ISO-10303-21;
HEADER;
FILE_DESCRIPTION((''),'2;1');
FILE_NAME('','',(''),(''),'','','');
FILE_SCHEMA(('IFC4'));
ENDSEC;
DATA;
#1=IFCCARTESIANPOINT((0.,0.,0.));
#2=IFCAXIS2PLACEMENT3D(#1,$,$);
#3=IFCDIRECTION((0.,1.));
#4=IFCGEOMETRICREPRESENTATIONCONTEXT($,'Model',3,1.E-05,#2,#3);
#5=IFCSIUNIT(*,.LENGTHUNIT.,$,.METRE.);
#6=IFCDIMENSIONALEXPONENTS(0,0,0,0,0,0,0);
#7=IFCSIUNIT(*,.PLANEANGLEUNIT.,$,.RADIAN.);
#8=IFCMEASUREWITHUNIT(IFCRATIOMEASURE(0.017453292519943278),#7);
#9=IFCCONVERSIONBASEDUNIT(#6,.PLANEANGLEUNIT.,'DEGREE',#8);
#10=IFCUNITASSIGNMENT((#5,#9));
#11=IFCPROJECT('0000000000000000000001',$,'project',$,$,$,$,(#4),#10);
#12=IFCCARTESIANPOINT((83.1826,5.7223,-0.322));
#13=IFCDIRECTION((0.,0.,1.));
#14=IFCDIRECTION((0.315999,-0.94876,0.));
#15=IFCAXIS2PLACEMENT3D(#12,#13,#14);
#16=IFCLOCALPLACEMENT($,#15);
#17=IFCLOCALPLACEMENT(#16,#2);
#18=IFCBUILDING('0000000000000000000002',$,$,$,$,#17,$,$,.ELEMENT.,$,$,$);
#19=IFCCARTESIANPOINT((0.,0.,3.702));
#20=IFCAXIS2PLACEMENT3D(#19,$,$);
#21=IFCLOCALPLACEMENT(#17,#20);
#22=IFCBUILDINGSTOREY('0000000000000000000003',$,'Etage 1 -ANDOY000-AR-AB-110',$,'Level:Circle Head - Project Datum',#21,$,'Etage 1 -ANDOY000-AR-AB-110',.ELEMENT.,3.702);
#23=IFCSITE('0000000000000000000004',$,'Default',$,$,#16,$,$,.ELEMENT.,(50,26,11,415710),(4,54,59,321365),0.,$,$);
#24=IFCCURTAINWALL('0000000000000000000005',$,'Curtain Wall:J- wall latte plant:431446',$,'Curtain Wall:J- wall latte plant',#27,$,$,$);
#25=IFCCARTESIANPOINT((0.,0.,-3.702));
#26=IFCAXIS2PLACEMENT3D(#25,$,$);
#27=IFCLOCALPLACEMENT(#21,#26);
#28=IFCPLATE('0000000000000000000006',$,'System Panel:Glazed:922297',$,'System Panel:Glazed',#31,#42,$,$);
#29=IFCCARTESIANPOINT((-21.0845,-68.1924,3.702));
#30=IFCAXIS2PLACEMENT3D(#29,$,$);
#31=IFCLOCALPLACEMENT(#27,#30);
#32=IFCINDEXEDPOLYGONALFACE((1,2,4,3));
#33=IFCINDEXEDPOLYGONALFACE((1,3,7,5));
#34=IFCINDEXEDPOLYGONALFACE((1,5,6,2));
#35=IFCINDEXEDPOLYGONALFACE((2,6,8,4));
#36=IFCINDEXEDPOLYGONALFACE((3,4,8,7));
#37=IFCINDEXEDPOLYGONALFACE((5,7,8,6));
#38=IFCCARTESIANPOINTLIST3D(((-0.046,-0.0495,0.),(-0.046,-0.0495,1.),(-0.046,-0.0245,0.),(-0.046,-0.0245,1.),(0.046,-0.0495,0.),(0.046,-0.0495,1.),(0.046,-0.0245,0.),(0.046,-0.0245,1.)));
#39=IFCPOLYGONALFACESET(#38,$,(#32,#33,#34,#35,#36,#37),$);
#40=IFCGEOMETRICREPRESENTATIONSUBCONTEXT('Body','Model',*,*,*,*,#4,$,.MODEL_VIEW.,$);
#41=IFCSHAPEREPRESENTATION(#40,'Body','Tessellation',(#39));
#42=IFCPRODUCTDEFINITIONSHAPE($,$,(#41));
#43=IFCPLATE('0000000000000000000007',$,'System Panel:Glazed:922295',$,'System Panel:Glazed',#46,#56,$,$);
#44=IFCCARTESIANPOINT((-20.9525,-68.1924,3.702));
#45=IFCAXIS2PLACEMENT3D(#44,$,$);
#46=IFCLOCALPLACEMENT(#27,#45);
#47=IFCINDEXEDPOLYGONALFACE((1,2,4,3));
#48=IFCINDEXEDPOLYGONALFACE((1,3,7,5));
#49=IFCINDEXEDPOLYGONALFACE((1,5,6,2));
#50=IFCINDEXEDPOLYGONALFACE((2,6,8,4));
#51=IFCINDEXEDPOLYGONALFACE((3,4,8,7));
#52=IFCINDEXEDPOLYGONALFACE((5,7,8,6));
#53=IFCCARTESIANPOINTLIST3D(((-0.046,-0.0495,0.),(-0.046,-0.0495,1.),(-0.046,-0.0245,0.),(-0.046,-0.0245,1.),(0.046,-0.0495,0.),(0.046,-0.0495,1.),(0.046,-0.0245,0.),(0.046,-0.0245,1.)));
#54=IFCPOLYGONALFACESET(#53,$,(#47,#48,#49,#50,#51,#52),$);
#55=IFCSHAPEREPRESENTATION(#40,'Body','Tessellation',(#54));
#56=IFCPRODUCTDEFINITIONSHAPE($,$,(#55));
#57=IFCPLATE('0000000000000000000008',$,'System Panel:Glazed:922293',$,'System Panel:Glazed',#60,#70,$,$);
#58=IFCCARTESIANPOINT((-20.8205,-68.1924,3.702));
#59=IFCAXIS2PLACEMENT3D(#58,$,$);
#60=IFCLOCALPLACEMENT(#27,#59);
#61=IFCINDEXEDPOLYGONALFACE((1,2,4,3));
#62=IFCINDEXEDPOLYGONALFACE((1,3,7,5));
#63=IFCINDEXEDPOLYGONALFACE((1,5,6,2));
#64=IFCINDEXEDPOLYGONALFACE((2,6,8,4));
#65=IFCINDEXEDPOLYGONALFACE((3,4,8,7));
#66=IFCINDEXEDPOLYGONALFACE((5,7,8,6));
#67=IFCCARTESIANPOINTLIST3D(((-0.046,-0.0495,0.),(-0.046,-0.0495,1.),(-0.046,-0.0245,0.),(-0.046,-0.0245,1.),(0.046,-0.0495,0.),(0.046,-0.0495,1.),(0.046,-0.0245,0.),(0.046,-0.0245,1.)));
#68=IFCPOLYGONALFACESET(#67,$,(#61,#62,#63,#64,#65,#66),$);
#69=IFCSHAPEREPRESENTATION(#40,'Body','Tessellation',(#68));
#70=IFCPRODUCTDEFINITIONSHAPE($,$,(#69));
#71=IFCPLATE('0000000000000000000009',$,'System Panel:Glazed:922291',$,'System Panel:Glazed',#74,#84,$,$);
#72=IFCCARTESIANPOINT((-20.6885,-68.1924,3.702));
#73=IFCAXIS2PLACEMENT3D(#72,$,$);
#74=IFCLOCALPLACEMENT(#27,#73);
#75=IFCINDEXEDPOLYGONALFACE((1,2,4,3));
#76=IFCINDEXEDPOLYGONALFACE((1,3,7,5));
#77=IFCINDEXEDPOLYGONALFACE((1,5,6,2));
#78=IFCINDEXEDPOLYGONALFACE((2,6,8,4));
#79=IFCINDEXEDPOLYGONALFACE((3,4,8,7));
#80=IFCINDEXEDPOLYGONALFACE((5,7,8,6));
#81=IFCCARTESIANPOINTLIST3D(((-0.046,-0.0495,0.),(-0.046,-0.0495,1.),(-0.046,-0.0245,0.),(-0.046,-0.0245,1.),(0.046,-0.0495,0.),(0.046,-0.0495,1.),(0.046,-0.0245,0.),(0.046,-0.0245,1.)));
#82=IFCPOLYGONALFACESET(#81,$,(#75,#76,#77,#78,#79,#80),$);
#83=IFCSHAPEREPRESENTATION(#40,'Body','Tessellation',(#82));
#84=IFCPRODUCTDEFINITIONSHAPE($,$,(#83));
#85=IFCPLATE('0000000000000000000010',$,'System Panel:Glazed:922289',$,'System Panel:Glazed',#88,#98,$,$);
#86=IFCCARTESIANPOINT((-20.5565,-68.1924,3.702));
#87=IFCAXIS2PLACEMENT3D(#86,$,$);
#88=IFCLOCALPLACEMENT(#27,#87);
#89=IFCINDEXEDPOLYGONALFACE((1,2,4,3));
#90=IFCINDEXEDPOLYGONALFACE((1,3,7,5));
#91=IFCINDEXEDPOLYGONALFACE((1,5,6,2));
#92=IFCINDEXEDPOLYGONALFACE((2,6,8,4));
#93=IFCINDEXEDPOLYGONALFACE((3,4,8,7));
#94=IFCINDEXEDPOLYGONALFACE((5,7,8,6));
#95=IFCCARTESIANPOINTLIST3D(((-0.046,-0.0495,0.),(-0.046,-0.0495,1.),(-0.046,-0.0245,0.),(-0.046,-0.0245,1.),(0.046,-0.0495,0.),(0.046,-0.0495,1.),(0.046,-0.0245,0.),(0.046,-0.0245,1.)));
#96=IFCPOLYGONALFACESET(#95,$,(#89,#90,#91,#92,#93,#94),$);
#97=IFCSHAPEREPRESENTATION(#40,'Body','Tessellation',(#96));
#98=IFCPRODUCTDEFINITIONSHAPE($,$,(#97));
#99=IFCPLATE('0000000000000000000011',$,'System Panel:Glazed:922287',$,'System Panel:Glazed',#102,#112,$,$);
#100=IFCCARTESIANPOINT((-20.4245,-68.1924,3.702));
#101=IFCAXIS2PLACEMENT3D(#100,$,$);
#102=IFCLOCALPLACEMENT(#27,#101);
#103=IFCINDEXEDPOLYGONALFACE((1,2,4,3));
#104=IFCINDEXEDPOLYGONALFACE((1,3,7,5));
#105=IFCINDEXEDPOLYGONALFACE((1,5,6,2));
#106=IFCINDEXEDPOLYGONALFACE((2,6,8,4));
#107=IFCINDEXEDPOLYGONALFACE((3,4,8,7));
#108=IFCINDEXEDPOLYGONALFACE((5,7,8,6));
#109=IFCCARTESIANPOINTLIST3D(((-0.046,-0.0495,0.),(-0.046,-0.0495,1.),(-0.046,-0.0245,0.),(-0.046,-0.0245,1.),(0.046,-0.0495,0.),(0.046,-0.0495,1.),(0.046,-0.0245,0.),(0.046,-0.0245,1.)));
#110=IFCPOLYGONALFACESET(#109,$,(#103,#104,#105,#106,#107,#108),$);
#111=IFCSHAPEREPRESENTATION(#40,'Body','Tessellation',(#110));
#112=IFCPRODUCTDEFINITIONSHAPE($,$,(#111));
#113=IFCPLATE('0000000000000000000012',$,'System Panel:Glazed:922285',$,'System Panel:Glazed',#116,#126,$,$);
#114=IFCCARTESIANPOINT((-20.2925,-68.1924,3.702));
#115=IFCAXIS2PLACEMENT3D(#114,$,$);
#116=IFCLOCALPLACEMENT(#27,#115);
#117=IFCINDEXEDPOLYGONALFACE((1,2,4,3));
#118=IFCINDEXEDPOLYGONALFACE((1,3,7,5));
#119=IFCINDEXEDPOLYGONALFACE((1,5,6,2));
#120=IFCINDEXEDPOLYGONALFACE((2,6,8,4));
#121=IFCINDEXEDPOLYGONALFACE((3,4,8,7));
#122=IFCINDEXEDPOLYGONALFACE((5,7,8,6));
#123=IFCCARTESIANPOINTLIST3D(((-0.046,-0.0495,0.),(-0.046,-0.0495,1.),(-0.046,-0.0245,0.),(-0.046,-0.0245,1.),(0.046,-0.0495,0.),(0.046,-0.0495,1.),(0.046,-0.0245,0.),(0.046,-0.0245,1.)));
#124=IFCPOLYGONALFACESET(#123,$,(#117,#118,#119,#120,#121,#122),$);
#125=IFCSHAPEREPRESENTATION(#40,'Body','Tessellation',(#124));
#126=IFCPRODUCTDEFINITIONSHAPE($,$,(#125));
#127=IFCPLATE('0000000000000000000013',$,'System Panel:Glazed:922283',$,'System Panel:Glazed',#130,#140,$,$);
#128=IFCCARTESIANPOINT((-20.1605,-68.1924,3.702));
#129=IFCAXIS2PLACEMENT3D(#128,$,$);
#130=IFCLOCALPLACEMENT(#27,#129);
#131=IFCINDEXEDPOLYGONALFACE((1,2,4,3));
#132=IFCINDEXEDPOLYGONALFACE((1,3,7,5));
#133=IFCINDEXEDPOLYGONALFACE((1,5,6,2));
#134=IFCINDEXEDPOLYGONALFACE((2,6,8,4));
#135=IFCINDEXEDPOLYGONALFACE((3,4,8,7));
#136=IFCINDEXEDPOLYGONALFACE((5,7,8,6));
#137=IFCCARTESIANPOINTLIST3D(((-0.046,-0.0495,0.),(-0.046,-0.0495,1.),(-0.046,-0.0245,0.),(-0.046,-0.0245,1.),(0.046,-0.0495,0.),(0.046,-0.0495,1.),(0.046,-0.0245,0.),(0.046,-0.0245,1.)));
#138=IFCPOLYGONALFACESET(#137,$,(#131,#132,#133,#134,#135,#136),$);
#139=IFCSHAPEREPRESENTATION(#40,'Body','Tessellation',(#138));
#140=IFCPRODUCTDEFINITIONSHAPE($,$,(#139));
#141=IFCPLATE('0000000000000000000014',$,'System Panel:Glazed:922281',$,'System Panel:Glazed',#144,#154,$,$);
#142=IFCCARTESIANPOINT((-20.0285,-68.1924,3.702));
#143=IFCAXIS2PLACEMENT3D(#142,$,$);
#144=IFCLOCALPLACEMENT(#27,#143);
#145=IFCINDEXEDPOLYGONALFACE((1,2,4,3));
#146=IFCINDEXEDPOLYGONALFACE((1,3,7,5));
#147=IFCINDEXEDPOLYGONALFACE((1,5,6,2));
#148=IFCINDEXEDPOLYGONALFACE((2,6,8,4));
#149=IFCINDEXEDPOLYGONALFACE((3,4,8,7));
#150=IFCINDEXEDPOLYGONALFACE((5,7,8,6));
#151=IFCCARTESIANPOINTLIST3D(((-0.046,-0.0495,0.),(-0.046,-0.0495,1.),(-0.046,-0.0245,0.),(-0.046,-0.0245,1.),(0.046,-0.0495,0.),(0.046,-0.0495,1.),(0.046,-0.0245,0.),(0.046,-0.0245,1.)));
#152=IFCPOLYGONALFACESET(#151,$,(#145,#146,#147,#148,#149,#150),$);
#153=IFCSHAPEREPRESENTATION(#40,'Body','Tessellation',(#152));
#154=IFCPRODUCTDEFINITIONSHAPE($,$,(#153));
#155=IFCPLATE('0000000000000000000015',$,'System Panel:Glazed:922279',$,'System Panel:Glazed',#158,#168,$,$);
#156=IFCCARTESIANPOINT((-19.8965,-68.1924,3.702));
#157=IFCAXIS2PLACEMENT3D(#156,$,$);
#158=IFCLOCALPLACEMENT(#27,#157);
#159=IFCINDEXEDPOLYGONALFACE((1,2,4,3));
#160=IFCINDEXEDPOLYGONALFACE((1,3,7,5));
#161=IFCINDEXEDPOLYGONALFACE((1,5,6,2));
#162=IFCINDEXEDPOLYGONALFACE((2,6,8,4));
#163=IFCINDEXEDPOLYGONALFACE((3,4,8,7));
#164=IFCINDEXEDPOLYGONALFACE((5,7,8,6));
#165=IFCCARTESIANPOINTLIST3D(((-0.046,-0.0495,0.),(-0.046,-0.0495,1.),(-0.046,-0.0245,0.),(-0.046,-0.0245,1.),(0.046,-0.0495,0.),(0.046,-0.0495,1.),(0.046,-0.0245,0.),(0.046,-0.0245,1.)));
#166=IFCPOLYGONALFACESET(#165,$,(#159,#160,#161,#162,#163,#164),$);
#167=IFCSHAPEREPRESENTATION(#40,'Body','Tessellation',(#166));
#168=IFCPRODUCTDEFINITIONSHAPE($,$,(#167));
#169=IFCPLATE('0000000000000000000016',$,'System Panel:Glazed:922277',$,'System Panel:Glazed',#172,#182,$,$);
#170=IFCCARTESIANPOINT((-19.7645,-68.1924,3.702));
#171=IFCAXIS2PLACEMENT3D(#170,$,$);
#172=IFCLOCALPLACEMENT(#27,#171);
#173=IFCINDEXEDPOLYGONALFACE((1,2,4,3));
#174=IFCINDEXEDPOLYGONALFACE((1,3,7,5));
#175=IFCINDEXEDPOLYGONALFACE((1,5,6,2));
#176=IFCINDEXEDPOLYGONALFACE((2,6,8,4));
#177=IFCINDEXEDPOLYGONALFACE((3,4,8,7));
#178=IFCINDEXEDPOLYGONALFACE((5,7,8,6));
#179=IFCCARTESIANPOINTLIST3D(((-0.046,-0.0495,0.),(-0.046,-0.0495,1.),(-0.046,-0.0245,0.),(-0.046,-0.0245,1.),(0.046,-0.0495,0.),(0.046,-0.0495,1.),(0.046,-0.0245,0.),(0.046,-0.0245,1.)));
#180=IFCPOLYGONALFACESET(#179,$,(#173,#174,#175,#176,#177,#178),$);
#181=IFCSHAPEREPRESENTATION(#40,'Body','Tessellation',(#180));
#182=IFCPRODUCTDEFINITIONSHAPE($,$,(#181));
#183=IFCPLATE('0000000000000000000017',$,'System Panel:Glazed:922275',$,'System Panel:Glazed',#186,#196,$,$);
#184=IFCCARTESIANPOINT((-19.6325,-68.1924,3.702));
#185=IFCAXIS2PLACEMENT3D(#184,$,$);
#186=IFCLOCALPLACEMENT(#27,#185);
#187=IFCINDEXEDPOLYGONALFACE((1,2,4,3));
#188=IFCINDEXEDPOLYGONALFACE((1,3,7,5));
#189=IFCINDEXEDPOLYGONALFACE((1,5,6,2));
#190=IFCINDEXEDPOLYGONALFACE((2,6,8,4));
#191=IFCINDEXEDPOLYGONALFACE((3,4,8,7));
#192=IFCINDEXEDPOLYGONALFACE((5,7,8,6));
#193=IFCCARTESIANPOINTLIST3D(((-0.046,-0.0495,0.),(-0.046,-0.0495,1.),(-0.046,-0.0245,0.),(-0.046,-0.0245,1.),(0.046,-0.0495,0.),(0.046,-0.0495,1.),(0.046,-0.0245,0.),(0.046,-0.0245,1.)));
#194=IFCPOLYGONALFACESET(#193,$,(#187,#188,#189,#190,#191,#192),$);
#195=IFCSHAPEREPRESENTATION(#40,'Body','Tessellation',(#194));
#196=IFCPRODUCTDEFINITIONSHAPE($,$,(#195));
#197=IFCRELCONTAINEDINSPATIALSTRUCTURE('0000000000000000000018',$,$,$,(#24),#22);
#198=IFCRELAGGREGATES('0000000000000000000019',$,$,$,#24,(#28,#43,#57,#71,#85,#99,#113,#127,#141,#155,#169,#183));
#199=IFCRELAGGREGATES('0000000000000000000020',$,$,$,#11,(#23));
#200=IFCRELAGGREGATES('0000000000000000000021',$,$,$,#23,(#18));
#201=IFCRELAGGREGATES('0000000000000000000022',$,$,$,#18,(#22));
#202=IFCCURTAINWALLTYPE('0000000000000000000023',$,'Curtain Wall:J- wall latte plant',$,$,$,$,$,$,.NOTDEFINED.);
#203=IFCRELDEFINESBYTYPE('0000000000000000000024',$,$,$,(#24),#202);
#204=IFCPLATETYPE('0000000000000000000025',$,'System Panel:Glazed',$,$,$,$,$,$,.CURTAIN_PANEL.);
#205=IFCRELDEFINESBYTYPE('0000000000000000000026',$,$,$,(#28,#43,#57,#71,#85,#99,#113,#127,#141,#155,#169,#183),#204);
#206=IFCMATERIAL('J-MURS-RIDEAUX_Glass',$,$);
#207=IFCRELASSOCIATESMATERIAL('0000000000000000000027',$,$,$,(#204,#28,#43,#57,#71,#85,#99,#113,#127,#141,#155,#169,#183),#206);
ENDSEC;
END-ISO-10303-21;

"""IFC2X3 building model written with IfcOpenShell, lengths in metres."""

from ifc_helpers import new_model, entity, si_unit, converted_unit, direction, frame, frame_2d, origin, place, context, subcontext, project, spatial, rectangle, extrude, source, transform, mapped, material, type_object, type_shapes, element, aggregate, save


model = new_model("IFC2X3")

# Units and contexts
model_context = context("Model", 3, precision=1e-05, world=origin(), true_north=direction((0.0, 1.0)))
body_context = subcontext(model_context, "Body", "Model", "MODEL_VIEW")
ifc_project = project(units=[si_unit("LENGTHUNIT", "METRE"), converted_unit("PLANEANGLEUNIT", "DEGREE", entity("IfcRatioMeasure", 0.017453292519943278), si_unit("PLANEANGLEUNIT", "RADIAN"), dimensions=[0, 0, 0, 0, 0, 0, 0])], contexts=[model_context])

# Site, building, storey
site_placement = place(None, frame((83.1826, 5.7223, -0.322), z_axis=(0.0, 0.0, 1.0), x_axis=(0.315999, -0.94876, 0.0)))
site = spatial("IfcSite", under=ifc_project, at=site_placement, Name="Default", CompositionType="ELEMENT", RefLatitude=(50, 26, 11, 415710), RefLongitude=(4, 54, 59, 321365), RefElevation=0.0)
building_placement = place(site_placement, origin())
building = spatial("IfcBuilding", under=site, at=building_placement, CompositionType="ELEMENT")
storey_placement = place(building_placement, frame((0.0, 0.0, 3.702)))
storey = spatial("IfcBuildingStorey", under=building, at=storey_placement, Name="Etage 1 -ANDOY000-AR-AB-110", ObjectType="Level:Circle Head - Project Datum", LongName="Etage 1 -ANDOY000-AR-AB-110", CompositionType="ELEMENT", Elevation=3.702)

# Curtain wall, plates
curtain_wall_type = type_object("IfcCurtainWallType", Name="Curtain Wall:J- wall latte plant", PredefinedType="NOTDEFINED")
curtain_wall_placement = place(storey_placement, frame((0.0, 0.0, -3.702)))
curtain_wall = element("IfcCurtainWall", 1, at=curtain_wall_placement, inside=storey, type_object=curtain_wall_type, Name="Curtain Wall:J- wall latte plant:431446", ObjectType="Curtain Wall:J- wall latte plant")
ifc_material_1 = material(Name="J-MURS-RIDEAUX_Glass")
plate_type = type_object("IfcPlateType", Name="System Panel:Glazed", PredefinedType="CURTAIN_PANEL", material=ifc_material_1)
shared_shape_1 = source(origin(), body_context, "Body", "SweptSolid", [
    extrude(rectangle(XDim=0.025, YDim=0.092, at=frame_2d((0.0, 0.0), x_axis=(1.0, 0.0))), frame((0.0, -0.037, 0.0), z_axis=(0.0, 0.0, 1.0), x_axis=(0.0, 1.0, 0.0)), (0.0, 0.0, 1.0), 1.0),
])
type_shapes(plate_type, [shared_shape_1])
plate_1_placement = place(curtain_wall_placement, frame((-21.0845, -68.1924, 3.702)))
plate_1 = element("IfcPlate", 2, at=plate_1_placement, type_object=plate_type, material=ifc_material_1, Name="System Panel:Glazed:922297", ObjectType="System Panel:Glazed", context=body_context, shape_type="MappedRepresentation", body=[
    mapped(shared_shape_1, transform((0.0, 0.0, 0.0), scale=1.0)),
])
plate_2_placement = place(curtain_wall_placement, frame((-20.9525, -68.1924, 3.702)))
plate_2 = element("IfcPlate", 3, at=plate_2_placement, type_object=plate_type, material=ifc_material_1, Name="System Panel:Glazed:922295", ObjectType="System Panel:Glazed", context=body_context, shape_type="MappedRepresentation", body=[
    mapped(shared_shape_1, transform((0.0, 0.0, 0.0), scale=1.0)),
])
plate_3_placement = place(curtain_wall_placement, frame((-20.8205, -68.1924, 3.702)))
plate_3 = element("IfcPlate", 4, at=plate_3_placement, type_object=plate_type, material=ifc_material_1, Name="System Panel:Glazed:922293", ObjectType="System Panel:Glazed", context=body_context, shape_type="MappedRepresentation", body=[
    mapped(shared_shape_1, transform((0.0, 0.0, 0.0), scale=1.0)),
])
plate_4_placement = place(curtain_wall_placement, frame((-20.6885, -68.1924, 3.702)))
plate_4 = element("IfcPlate", 5, at=plate_4_placement, type_object=plate_type, material=ifc_material_1, Name="System Panel:Glazed:922291", ObjectType="System Panel:Glazed", context=body_context, shape_type="MappedRepresentation", body=[
    mapped(shared_shape_1, transform((0.0, 0.0, 0.0), scale=1.0)),
])
plate_5_placement = place(curtain_wall_placement, frame((-20.5565, -68.1924, 3.702)))
plate_5 = element("IfcPlate", 6, at=plate_5_placement, type_object=plate_type, material=ifc_material_1, Name="System Panel:Glazed:922289", ObjectType="System Panel:Glazed", context=body_context, shape_type="MappedRepresentation", body=[
    mapped(shared_shape_1, transform((0.0, 0.0, 0.0), scale=1.0)),
])
plate_6_placement = place(curtain_wall_placement, frame((-20.4245, -68.1924, 3.702)))
plate_6 = element("IfcPlate", 7, at=plate_6_placement, type_object=plate_type, material=ifc_material_1, Name="System Panel:Glazed:922287", ObjectType="System Panel:Glazed", context=body_context, shape_type="MappedRepresentation", body=[
    mapped(shared_shape_1, transform((0.0, 0.0, 0.0), scale=1.0)),
])
plate_7_placement = place(curtain_wall_placement, frame((-20.2925, -68.1924, 3.702)))
plate_7 = element("IfcPlate", 8, at=plate_7_placement, type_object=plate_type, material=ifc_material_1, Name="System Panel:Glazed:922285", ObjectType="System Panel:Glazed", context=body_context, shape_type="MappedRepresentation", body=[
    mapped(shared_shape_1, transform((0.0, 0.0, 0.0), scale=1.0)),
])
plate_8_placement = place(curtain_wall_placement, frame((-20.1605, -68.1924, 3.702)))
plate_8 = element("IfcPlate", 9, at=plate_8_placement, type_object=plate_type, material=ifc_material_1, Name="System Panel:Glazed:922283", ObjectType="System Panel:Glazed", context=body_context, shape_type="MappedRepresentation", body=[
    mapped(shared_shape_1, transform((0.0, 0.0, 0.0), scale=1.0)),
])
plate_9_placement = place(curtain_wall_placement, frame((-20.0285, -68.1924, 3.702)))
plate_9 = element("IfcPlate", 10, at=plate_9_placement, type_object=plate_type, material=ifc_material_1, Name="System Panel:Glazed:922281", ObjectType="System Panel:Glazed", context=body_context, shape_type="MappedRepresentation", body=[
    mapped(shared_shape_1, transform((0.0, 0.0, 0.0), scale=1.0)),
])
plate_10_placement = place(curtain_wall_placement, frame((-19.8965, -68.1924, 3.702)))
plate_10 = element("IfcPlate", 11, at=plate_10_placement, type_object=plate_type, material=ifc_material_1, Name="System Panel:Glazed:922279", ObjectType="System Panel:Glazed", context=body_context, shape_type="MappedRepresentation", body=[
    mapped(shared_shape_1, transform((0.0, 0.0, 0.0), scale=1.0)),
])
plate_11_placement = place(curtain_wall_placement, frame((-19.7645, -68.1924, 3.702)))
plate_11 = element("IfcPlate", 12, at=plate_11_placement, type_object=plate_type, material=ifc_material_1, Name="System Panel:Glazed:922277", ObjectType="System Panel:Glazed", context=body_context, shape_type="MappedRepresentation", body=[
    mapped(shared_shape_1, transform((0.0, 0.0, 0.0), scale=1.0)),
])
plate_12_placement = place(curtain_wall_placement, frame((-19.6325, -68.1924, 3.702)))
plate_12 = element("IfcPlate", 13, at=plate_12_placement, type_object=plate_type, material=ifc_material_1, Name="System Panel:Glazed:922275", ObjectType="System Panel:Glazed", context=body_context, shape_type="MappedRepresentation", body=[
    mapped(shared_shape_1, transform((0.0, 0.0, 0.0), scale=1.0)),
])
aggregate(curtain_wall, [plate_1, plate_2, plate_3, plate_4, plate_5, plate_6, plate_7, plate_8, plate_9, plate_10, plate_11, plate_12])

save(model, "model.ifc")
